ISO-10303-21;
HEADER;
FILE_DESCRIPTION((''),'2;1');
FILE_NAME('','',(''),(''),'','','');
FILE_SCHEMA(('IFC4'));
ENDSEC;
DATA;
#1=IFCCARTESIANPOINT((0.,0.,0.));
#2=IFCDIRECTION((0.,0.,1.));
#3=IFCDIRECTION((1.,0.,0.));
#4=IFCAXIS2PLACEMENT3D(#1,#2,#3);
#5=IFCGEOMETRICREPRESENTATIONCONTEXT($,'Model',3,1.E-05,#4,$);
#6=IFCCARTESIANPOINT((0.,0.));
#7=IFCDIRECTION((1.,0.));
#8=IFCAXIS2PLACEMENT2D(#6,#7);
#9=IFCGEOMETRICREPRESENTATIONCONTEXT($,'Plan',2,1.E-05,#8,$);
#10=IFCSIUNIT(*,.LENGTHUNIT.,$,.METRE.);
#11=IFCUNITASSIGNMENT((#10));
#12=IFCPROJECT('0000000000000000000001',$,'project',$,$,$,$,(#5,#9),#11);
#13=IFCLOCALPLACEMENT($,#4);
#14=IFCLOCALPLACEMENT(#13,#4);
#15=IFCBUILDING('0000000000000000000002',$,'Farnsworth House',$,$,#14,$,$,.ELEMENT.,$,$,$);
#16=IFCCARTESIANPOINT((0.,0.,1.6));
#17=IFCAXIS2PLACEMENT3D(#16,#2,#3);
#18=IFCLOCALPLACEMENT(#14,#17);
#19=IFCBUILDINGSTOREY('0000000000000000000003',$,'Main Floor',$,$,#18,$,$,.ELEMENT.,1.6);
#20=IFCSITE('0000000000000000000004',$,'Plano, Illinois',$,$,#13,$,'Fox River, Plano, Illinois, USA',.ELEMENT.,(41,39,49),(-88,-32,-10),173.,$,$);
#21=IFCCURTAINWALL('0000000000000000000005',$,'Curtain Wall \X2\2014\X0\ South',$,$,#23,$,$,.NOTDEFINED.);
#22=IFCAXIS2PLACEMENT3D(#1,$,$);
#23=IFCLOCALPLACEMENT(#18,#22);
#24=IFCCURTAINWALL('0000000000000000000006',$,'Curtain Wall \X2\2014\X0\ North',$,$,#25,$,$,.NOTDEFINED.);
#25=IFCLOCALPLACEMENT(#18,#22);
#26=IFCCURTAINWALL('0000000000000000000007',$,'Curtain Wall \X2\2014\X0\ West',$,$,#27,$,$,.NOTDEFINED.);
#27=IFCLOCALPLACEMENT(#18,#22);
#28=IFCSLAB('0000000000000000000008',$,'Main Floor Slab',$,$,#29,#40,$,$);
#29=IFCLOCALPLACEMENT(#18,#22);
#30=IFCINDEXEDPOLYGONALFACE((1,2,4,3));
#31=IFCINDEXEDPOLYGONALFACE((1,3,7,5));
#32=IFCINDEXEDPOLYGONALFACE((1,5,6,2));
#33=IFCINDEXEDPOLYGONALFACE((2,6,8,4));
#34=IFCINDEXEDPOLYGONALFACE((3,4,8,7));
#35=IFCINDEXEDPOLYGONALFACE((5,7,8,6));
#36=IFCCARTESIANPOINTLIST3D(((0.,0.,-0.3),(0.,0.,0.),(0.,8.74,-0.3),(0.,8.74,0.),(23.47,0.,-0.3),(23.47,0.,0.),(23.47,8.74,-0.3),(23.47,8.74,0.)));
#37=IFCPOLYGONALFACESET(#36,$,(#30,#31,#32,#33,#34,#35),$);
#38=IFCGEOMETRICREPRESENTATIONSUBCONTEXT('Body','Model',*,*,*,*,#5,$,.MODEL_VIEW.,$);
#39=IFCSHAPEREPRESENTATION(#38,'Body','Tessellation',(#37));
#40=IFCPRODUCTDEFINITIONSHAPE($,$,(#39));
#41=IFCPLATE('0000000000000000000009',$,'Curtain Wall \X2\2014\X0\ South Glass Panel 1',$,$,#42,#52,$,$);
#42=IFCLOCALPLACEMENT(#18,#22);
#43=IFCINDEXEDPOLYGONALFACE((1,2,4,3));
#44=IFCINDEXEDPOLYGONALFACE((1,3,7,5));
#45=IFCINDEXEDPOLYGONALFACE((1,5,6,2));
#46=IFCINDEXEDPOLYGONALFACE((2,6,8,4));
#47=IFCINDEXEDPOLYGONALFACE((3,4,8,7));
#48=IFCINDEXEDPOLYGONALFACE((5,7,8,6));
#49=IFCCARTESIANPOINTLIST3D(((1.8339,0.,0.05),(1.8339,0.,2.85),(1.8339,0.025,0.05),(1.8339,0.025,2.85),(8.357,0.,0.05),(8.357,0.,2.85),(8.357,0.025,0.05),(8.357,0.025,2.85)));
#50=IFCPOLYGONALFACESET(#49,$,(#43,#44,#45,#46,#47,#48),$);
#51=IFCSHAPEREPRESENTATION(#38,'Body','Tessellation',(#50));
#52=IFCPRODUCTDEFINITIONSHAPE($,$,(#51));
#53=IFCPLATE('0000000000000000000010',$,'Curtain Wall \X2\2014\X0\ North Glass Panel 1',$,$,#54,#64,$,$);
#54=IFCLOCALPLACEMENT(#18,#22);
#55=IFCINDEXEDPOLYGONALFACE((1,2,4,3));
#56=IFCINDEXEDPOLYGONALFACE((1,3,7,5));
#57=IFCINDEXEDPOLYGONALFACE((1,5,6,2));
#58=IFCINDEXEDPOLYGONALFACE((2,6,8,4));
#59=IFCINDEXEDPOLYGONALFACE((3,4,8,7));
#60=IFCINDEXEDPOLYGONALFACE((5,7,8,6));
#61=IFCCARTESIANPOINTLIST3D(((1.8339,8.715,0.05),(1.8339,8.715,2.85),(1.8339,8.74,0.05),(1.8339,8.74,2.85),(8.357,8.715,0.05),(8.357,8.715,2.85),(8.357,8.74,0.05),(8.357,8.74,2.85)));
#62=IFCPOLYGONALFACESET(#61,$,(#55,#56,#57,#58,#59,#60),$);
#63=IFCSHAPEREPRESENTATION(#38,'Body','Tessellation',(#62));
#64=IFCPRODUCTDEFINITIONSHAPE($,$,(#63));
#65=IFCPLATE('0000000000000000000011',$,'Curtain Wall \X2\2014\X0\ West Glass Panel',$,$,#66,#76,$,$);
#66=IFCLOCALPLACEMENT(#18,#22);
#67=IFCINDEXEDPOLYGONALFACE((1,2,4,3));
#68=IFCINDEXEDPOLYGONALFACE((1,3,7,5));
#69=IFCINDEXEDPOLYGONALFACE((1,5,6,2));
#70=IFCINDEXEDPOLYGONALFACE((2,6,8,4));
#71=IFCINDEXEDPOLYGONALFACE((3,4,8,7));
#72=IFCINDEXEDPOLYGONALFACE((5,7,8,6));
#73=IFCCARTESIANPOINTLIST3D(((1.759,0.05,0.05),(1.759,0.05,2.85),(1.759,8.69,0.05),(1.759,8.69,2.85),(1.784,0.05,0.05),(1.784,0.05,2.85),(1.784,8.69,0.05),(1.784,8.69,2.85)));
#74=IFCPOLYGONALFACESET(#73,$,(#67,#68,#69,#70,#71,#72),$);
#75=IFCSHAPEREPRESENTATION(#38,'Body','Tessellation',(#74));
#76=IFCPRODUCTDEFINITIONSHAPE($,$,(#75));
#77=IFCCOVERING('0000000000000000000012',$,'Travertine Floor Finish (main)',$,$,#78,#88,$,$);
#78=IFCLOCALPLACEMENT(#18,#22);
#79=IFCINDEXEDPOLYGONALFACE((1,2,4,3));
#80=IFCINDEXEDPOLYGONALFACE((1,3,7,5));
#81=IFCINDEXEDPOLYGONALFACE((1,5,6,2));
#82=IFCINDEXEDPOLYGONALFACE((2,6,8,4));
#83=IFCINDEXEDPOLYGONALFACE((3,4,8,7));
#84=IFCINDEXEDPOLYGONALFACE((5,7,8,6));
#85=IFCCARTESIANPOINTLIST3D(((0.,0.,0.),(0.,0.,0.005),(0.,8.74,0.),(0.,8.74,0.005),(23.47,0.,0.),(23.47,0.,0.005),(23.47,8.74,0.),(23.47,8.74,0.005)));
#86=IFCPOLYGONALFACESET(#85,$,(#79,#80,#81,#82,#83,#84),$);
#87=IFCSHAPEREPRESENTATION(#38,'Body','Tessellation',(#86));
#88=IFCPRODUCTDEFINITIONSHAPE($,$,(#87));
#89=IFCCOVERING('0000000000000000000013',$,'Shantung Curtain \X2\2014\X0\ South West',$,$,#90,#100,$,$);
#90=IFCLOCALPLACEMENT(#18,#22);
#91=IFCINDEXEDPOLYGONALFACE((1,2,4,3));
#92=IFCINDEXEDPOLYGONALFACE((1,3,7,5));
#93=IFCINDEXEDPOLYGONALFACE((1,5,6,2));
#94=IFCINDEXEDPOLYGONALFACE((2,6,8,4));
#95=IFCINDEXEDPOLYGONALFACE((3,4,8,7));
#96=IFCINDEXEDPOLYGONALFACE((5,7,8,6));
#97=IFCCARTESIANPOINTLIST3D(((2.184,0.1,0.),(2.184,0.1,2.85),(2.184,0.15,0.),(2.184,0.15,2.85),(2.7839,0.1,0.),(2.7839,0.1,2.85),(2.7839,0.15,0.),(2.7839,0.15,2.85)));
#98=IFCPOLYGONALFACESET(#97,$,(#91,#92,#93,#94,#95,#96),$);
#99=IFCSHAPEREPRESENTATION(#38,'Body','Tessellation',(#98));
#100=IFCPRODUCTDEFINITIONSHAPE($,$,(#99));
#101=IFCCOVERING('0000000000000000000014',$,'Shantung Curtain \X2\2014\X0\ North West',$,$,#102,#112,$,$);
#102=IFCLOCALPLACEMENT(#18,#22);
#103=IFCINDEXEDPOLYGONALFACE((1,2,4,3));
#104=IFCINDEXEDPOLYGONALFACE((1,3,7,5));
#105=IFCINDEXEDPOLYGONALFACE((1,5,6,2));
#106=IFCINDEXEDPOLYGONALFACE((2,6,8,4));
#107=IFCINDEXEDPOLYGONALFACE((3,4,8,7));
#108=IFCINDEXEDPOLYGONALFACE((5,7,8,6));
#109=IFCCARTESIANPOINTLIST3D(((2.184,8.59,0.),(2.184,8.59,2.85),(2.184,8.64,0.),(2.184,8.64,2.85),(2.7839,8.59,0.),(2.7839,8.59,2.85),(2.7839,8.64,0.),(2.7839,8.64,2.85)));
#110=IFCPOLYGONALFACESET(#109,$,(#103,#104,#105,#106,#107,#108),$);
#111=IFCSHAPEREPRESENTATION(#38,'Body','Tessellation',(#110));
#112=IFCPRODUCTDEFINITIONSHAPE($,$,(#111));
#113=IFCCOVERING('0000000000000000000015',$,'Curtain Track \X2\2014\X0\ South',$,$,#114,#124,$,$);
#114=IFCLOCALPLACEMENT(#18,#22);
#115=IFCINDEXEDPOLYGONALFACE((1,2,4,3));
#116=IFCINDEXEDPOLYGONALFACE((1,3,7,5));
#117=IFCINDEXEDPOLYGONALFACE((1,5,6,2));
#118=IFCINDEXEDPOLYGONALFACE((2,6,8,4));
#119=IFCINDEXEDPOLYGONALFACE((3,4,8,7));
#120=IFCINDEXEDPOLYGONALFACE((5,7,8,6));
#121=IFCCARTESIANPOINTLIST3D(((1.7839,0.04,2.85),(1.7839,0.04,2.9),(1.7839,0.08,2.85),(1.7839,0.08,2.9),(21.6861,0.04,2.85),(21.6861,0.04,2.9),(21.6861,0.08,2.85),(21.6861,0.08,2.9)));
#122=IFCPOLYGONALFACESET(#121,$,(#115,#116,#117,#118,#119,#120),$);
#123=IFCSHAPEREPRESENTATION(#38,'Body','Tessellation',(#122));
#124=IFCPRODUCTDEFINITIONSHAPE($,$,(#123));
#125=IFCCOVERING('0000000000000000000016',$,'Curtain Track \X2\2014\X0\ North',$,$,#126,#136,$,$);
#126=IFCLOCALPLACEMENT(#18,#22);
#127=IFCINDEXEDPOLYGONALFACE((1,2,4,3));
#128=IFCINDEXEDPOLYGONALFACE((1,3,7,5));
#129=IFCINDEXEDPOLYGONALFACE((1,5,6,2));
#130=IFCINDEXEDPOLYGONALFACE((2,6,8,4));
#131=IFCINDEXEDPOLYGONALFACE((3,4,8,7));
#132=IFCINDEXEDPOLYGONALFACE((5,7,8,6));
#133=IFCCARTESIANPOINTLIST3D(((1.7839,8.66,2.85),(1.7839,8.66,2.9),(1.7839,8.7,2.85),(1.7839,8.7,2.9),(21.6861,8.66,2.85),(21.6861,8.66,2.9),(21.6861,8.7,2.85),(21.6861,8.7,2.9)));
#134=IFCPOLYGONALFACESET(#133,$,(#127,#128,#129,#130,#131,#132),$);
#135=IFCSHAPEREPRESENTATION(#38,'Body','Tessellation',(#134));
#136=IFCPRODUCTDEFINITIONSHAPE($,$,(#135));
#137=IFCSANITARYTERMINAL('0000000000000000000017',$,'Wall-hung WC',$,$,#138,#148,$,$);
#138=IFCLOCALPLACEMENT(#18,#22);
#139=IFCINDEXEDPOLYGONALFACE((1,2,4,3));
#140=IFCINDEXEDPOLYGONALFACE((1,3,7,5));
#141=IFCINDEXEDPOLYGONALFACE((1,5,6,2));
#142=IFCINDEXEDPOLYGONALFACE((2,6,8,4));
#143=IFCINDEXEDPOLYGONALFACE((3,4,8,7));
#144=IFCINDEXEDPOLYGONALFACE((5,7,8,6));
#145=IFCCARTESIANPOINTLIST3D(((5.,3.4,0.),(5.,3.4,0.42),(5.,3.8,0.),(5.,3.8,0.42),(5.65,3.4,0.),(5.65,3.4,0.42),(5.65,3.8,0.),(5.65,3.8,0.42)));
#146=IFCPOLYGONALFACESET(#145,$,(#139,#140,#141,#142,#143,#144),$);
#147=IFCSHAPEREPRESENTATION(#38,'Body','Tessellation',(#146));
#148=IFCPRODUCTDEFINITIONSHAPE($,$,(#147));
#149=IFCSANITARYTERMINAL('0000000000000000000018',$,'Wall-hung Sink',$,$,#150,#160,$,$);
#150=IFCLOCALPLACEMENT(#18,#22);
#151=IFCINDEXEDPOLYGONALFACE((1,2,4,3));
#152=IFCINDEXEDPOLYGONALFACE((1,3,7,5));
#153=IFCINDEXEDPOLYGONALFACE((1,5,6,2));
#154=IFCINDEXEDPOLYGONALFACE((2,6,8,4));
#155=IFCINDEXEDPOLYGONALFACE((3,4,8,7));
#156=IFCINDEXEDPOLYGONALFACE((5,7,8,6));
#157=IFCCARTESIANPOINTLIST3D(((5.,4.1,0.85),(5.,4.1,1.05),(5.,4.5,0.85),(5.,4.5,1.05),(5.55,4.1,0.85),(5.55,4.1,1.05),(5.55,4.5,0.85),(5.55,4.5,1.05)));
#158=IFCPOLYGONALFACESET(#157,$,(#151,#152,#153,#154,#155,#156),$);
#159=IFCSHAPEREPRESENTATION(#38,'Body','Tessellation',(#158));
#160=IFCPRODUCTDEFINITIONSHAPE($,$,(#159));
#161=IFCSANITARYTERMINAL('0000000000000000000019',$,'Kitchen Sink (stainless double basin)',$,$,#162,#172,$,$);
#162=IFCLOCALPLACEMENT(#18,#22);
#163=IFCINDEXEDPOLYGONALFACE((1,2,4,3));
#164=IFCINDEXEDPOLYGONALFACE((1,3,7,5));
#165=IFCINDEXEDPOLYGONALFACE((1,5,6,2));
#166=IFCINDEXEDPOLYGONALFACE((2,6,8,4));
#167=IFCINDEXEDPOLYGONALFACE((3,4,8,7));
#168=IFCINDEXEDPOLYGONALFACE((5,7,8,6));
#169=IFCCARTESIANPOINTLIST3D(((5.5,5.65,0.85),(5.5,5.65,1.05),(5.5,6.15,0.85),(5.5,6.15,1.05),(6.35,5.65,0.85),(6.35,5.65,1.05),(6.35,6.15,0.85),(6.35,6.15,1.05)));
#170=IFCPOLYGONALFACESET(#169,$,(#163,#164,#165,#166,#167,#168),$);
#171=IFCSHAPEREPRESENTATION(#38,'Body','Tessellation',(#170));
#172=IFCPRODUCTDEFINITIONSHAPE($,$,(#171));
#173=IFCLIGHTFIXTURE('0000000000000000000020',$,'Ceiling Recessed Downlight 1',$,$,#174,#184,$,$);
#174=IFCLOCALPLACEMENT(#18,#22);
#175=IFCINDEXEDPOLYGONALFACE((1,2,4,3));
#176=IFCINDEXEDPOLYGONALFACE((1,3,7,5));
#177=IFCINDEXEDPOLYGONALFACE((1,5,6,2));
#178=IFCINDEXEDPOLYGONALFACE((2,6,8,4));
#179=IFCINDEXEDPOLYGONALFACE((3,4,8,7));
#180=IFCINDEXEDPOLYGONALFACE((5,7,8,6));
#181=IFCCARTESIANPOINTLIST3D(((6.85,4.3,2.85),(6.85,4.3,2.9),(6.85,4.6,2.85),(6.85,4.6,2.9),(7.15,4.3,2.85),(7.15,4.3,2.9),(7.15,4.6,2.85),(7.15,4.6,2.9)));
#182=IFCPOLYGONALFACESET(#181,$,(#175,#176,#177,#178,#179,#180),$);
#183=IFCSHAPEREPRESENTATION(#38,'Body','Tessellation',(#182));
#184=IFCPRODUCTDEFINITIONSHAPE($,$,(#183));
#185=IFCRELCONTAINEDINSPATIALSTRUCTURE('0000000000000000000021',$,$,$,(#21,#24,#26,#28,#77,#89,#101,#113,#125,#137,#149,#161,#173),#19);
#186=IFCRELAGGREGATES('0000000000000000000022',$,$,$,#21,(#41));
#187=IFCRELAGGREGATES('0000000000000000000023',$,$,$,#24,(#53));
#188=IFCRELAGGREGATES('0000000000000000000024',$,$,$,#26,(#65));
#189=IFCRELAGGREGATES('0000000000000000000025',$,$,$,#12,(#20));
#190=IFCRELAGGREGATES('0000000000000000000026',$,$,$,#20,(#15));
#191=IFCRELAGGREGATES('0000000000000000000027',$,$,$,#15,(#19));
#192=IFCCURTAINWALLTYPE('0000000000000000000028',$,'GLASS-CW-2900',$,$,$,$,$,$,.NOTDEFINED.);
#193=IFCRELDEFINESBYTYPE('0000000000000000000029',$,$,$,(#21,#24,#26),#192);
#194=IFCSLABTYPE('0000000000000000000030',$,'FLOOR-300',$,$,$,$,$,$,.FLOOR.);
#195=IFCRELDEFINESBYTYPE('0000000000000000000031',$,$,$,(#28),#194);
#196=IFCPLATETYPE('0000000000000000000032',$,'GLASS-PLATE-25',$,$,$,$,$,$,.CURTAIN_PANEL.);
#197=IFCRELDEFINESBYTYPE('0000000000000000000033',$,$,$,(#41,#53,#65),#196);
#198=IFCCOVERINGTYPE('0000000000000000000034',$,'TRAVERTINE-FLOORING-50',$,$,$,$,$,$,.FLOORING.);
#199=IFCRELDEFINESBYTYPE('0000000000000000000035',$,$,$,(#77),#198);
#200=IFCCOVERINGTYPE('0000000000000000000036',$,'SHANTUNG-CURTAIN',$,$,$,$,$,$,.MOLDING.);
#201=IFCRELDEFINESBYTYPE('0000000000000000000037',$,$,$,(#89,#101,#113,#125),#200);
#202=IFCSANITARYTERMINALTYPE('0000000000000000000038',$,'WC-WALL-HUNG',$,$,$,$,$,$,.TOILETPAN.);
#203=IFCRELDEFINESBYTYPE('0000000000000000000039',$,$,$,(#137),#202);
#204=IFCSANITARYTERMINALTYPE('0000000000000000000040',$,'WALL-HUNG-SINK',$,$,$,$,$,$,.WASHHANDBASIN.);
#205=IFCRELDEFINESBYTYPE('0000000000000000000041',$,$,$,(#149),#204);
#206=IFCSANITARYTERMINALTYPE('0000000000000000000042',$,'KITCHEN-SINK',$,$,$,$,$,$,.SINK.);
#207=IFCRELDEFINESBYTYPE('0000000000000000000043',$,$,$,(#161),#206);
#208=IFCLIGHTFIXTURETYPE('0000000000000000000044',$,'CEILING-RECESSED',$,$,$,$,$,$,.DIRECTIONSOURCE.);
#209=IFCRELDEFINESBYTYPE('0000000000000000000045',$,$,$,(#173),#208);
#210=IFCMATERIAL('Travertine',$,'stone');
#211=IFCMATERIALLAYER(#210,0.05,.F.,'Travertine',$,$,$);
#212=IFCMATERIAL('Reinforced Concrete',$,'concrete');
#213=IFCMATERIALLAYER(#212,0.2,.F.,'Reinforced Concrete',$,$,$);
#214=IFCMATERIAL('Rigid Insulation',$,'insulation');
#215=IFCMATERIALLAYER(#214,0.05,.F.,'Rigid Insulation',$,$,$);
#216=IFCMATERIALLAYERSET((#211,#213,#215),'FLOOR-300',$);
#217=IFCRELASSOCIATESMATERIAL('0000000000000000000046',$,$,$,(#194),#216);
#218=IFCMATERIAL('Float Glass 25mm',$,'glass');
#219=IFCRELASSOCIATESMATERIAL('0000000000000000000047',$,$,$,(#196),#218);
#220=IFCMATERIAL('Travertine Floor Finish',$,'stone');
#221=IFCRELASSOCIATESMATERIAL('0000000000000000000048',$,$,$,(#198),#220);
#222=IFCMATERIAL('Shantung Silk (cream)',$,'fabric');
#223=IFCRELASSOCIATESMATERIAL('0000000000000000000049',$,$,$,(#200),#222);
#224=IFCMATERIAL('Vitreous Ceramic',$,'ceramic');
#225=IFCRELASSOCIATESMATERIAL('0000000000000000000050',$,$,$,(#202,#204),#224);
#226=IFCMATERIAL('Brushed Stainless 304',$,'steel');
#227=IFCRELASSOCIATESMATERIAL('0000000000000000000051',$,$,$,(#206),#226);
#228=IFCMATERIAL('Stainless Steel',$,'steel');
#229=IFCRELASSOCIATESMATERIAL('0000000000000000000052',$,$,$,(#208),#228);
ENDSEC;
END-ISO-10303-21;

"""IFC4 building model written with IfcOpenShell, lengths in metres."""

from ifc_helpers import new_model, si_unit, frame, origin_with_axes, origin_2d_with_axis, place, context, subcontext, project, spatial, rectangle, extrude, material, layer, layer_set, layer_usage, type_object, element, aggregate, save


model = new_model("IFC4")

# Units and contexts
model_context = context("Model", 3, precision=1e-05, world=origin_with_axes())
plan_context = context("Plan", 2, precision=1e-05, world=origin_2d_with_axis())
body_context = subcontext(model_context, "Body", "Model", "MODEL_VIEW")
ifc_project = project(units=[si_unit("LENGTHUNIT", "METRE")], contexts=[model_context, plan_context])

# Site, building, storey
site_placement = place(None, origin_with_axes())
site = spatial("IfcSite", under=ifc_project, at=site_placement, Name="Plano, Illinois", LongName="Fox River, Plano, Illinois, USA", CompositionType="ELEMENT", RefLatitude=(41, 39, 49), RefLongitude=(-88, -32, -10), RefElevation=173.0)
building_placement = place(site_placement, origin_with_axes())
building = spatial("IfcBuilding", under=site, at=building_placement, Name="Farnsworth House", CompositionType="ELEMENT")
storey_placement = place(building_placement, frame((0.0, 0.0, 1.6), z_axis=(0.0, 0.0, 1.0), x_axis=(1.0, 0.0, 0.0)))
storey = spatial("IfcBuildingStorey", under=building, at=storey_placement, Name="Main Floor", CompositionType="ELEMENT", Elevation=1.6)

# Curtain walls
curtain_wall_type = type_object("IfcCurtainWallType", Name="GLASS-CW-2900", PredefinedType="NOTDEFINED")
curtain_wall_1_placement = place(storey_placement, frame((1.7839, 0.0, 0.0), z_axis=(0.0, 0.0, 1.0), x_axis=(1.0, 0.0, 0.0)))
curtain_wall_1 = element("IfcCurtainWall", 1, at=curtain_wall_1_placement, inside=storey, type_object=curtain_wall_type, Name="Curtain Wall — South", PredefinedType="NOTDEFINED")
ifc_material_1 = material(Name="Stainless Steel", Category="steel")
curtain_wall_2_placement = place(storey_placement, frame((1.7839, 8.715, 0.0), z_axis=(0.0, 0.0, 1.0), x_axis=(1.0, 0.0, 0.0)))
curtain_wall_2 = element("IfcCurtainWall", 2, at=curtain_wall_2_placement, inside=storey, type_object=curtain_wall_type, Name="Curtain Wall — North", PredefinedType="NOTDEFINED")
curtain_wall_3_placement = place(storey_placement, frame((1.7839, 0.0, 0.0), z_axis=(0.0, 0.0, 1.0), x_axis=(0.0, 1.0, 0.0)))
curtain_wall_3 = element("IfcCurtainWall", 3, at=curtain_wall_3_placement, inside=storey, type_object=curtain_wall_type, Name="Curtain Wall — West", PredefinedType="NOTDEFINED")

# Slab
ifc_material_2 = material(Name="Travertine", Category="stone")
ifc_layer_1 = layer(ifc_material_2, 0.05, ventilated=False, Name="Travertine")
ifc_material_3 = material(Name="Reinforced Concrete", Category="concrete")
ifc_layer_2 = layer(ifc_material_3, 0.2, ventilated=False, Name="Reinforced Concrete")
ifc_material_4 = material(Name="Rigid Insulation", Category="insulation")
ifc_layer_3 = layer(ifc_material_4, 0.05, ventilated=False, Name="Rigid Insulation")
ifc_layer_set = layer_set([ifc_layer_1, ifc_layer_2, ifc_layer_3], Name="FLOOR-300")
ifc_layer_usage = layer_usage(ifc_layer_set, "AXIS3", "POSITIVE", -0.3)
slab_type = type_object("IfcSlabType", Name="FLOOR-300", PredefinedType="FLOOR", material=ifc_layer_usage)
slab_placement = place(storey_placement, frame((0.0, 0.0, -0.3), z_axis=(0.0, 0.0, 1.0), x_axis=(1.0, 0.0, 0.0)))
element("IfcSlab", 4, at=slab_placement, inside=storey, type_object=slab_type, Name="Main Floor Slab", context=body_context, shape_type="SweptSolid", body=[
    extrude(rectangle(XDim=23.47, YDim=8.74, at=origin_2d_with_axis()), frame((11.735, 4.37, 0.0), z_axis=(0.0, 0.0, 1.0), x_axis=(1.0, 0.0, 0.0)), (0.0, 0.0, 1.0), 0.3),
])

# Plates
ifc_material_5 = material(Name="Float Glass 25mm", Category="glass")
plate_type = type_object("IfcPlateType", Name="GLASS-PLATE-25", PredefinedType="CURTAIN_PANEL", material=ifc_material_5)
plate_1_placement = place(curtain_wall_1_placement, frame((0.05, 0.0, 0.05), z_axis=(0.0, 0.0, 1.0), x_axis=(1.0, 0.0, 0.0)))
plate_1 = element("IfcPlate", 5, at=plate_1_placement, type_object=plate_type, Name="Curtain Wall — South Glass Panel 1", context=body_context, shape_type="SweptSolid", body=[
    extrude(rectangle(XDim=6.523, YDim=0.025, at=origin_2d_with_axis()), frame((3.2615, 0.0125, 0.0), z_axis=(0.0, 0.0, 1.0), x_axis=(1.0, 0.0, 0.0)), (0.0, 0.0, 1.0), 2.8),
])
aggregate(curtain_wall_1, [plate_1])
plate_2_placement = place(curtain_wall_2_placement, frame((0.05, 0.0, 0.05), z_axis=(0.0, 0.0, 1.0), x_axis=(1.0, 0.0, 0.0)))
plate_2 = element("IfcPlate", 6, at=plate_2_placement, type_object=plate_type, Name="Curtain Wall — North Glass Panel 1", context=body_context, shape_type="SweptSolid", body=[
    extrude(rectangle(XDim=6.523, YDim=0.025, at=origin_2d_with_axis()), frame((3.2615, 0.0125, 0.0), z_axis=(0.0, 0.0, 1.0), x_axis=(1.0, 0.0, 0.0)), (0.0, 0.0, 1.0), 2.8),
])
aggregate(curtain_wall_2, [plate_2])
plate_3_placement = place(curtain_wall_3_placement, frame((0.05, 0.0, 0.05), z_axis=(0.0, 0.0, 1.0), x_axis=(1.0, 0.0, 0.0)))
plate_3 = element("IfcPlate", 7, at=plate_3_placement, type_object=plate_type, Name="Curtain Wall — West Glass Panel", context=body_context, shape_type="SweptSolid", body=[
    extrude(rectangle(XDim=8.64, YDim=0.025, at=origin_2d_with_axis()), frame((4.32, 0.0125, 0.0), z_axis=(0.0, 0.0, 1.0), x_axis=(1.0, 0.0, 0.0)), (0.0, 0.0, 1.0), 2.8),
])
aggregate(curtain_wall_3, [plate_3])

# Coverings
ifc_material_6 = material(Name="Travertine Floor Finish", Category="stone")
covering_type_1 = type_object("IfcCoveringType", Name="TRAVERTINE-FLOORING-50", PredefinedType="FLOORING", material=ifc_material_6)
covering_placement = place(storey_placement, origin_with_axes())
element("IfcCovering", 8, at=covering_placement, inside=storey, type_object=covering_type_1, Name="Travertine Floor Finish (main)", context=body_context, shape_type="SweptSolid", body=[
    extrude(rectangle(XDim=23.47, YDim=8.74, at=origin_2d_with_axis()), frame((11.735, 4.37, 0.0), z_axis=(0.0, 0.0, 1.0), x_axis=(1.0, 0.0, 0.0)), (0.0, 0.0, 1.0), 0.005),
])
ifc_material_7 = material(Name="Shantung Silk (cream)", Category="fabric")
covering_type_2 = type_object("IfcCoveringType", Name="SHANTUNG-CURTAIN", PredefinedType="MOLDING", material=ifc_material_7)
for number, where, z_axis, x_axis, name in (
    (9, (2.1839, 0.1, 0.0), (0.0, 0.0, 1.0), (1.0, 0.0, 0.0), "Shantung Curtain — South West"),
    (10, (2.1839, 8.59, 0.0), (0.0, 0.0, 1.0), (1.0, 0.0, 0.0), "Shantung Curtain — North West"),
):
    element("IfcCovering", number, at=place(storey_placement, frame(where, z_axis=z_axis, x_axis=x_axis)), inside=storey, type_object=covering_type_2, Name=name, context=body_context, shape_type="SweptSolid", body=[
        extrude(rectangle(XDim=0.6, YDim=0.05, at=origin_2d_with_axis()), frame((0.3, 0.025, 0.0), z_axis=(0.0, 0.0, 1.0), x_axis=(1.0, 0.0, 0.0)), (0.0, 0.0, 1.0), 2.85),
    ])
for number, where, z_axis, x_axis, name in (
    (11, (1.7839, 0.04, 2.85), (0.0, 0.0, 1.0), (1.0, 0.0, 0.0), "Curtain Track — South"),
    (12, (1.7839, 8.66, 2.85), (0.0, 0.0, 1.0), (1.0, 0.0, 0.0), "Curtain Track — North"),
):
    element("IfcCovering", number, at=place(storey_placement, frame(where, z_axis=z_axis, x_axis=x_axis)), inside=storey, type_object=covering_type_2, Name=name, context=body_context, shape_type="SweptSolid", body=[
        extrude(rectangle(XDim=19.9021, YDim=0.04, at=origin_2d_with_axis()), frame((9.9511, 0.02, 0.0), z_axis=(0.0, 0.0, 1.0), x_axis=(1.0, 0.0, 0.0)), (0.0, 0.0, 1.0), 0.05),
    ])

# Sanitary terminals
ifc_material_8 = material(Name="Vitreous Ceramic", Category="ceramic")
sanitary_terminal_type_1 = type_object("IfcSanitaryTerminalType", Name="WC-WALL-HUNG", PredefinedType="TOILETPAN", material=ifc_material_8)
sanitary_terminal_1_placement = place(storey_placement, frame((5.0, 3.4, 0.0), z_axis=(0.0, 0.0, 1.0), x_axis=(1.0, 0.0, 0.0)))
element("IfcSanitaryTerminal", 13, at=sanitary_terminal_1_placement, inside=storey, type_object=sanitary_terminal_type_1, Name="Wall-hung WC", context=body_context, shape_type="SweptSolid", body=[
    extrude(rectangle(XDim=0.65, YDim=0.4, at=origin_2d_with_axis()), frame((0.325, 0.2, 0.0), z_axis=(0.0, 0.0, 1.0), x_axis=(1.0, 0.0, 0.0)), (0.0, 0.0, 1.0), 0.42),
])
sanitary_terminal_type_2 = type_object("IfcSanitaryTerminalType", Name="WALL-HUNG-SINK", PredefinedType="WASHHANDBASIN", material=ifc_material_8)
sanitary_terminal_2_placement = place(storey_placement, frame((5.0, 4.1, 0.85), z_axis=(0.0, 0.0, 1.0), x_axis=(1.0, 0.0, 0.0)))
element("IfcSanitaryTerminal", 14, at=sanitary_terminal_2_placement, inside=storey, type_object=sanitary_terminal_type_2, Name="Wall-hung Sink", context=body_context, shape_type="SweptSolid", body=[
    extrude(rectangle(XDim=0.55, YDim=0.4, at=origin_2d_with_axis()), frame((0.275, 0.2, 0.0), z_axis=(0.0, 0.0, 1.0), x_axis=(1.0, 0.0, 0.0)), (0.0, 0.0, 1.0), 0.2),
])
ifc_material_9 = material(Name="Brushed Stainless 304", Category="steel")
sanitary_terminal_type_3 = type_object("IfcSanitaryTerminalType", Name="KITCHEN-SINK", PredefinedType="SINK", material=ifc_material_9)
sanitary_terminal_3_placement = place(storey_placement, frame((5.5, 5.65, 0.85), z_axis=(0.0, 0.0, 1.0), x_axis=(1.0, 0.0, 0.0)))
element("IfcSanitaryTerminal", 15, at=sanitary_terminal_3_placement, inside=storey, type_object=sanitary_terminal_type_3, Name="Kitchen Sink (stainless double basin)", context=body_context, shape_type="SweptSolid", body=[
    extrude(rectangle(XDim=0.85, YDim=0.5, at=origin_2d_with_axis()), frame((0.425, 0.25, 0.0), z_axis=(0.0, 0.0, 1.0), x_axis=(1.0, 0.0, 0.0)), (0.0, 0.0, 1.0), 0.2),
])

# Light fixture
light_fixture_type = type_object("IfcLightFixtureType", Name="CEILING-RECESSED", PredefinedType="DIRECTIONSOURCE", material=ifc_material_1)
light_fixture_placement = place(storey_placement, frame((6.85, 4.3, 2.85), z_axis=(0.0, 0.0, 1.0), x_axis=(1.0, 0.0, 0.0)))
element("IfcLightFixture", 16, at=light_fixture_placement, inside=storey, type_object=light_fixture_type, Name="Ceiling Recessed Downlight 1", context=body_context, shape_type="SweptSolid", body=[
    extrude(rectangle(XDim=0.3, YDim=0.3, at=origin_2d_with_axis()), frame((0.15, 0.15, 0.0), z_axis=(0.0, 0.0, 1.0), x_axis=(1.0, 0.0, 0.0)), (0.0, 0.0, 1.0), 0.05),
])

save(model, "model.ifc")
